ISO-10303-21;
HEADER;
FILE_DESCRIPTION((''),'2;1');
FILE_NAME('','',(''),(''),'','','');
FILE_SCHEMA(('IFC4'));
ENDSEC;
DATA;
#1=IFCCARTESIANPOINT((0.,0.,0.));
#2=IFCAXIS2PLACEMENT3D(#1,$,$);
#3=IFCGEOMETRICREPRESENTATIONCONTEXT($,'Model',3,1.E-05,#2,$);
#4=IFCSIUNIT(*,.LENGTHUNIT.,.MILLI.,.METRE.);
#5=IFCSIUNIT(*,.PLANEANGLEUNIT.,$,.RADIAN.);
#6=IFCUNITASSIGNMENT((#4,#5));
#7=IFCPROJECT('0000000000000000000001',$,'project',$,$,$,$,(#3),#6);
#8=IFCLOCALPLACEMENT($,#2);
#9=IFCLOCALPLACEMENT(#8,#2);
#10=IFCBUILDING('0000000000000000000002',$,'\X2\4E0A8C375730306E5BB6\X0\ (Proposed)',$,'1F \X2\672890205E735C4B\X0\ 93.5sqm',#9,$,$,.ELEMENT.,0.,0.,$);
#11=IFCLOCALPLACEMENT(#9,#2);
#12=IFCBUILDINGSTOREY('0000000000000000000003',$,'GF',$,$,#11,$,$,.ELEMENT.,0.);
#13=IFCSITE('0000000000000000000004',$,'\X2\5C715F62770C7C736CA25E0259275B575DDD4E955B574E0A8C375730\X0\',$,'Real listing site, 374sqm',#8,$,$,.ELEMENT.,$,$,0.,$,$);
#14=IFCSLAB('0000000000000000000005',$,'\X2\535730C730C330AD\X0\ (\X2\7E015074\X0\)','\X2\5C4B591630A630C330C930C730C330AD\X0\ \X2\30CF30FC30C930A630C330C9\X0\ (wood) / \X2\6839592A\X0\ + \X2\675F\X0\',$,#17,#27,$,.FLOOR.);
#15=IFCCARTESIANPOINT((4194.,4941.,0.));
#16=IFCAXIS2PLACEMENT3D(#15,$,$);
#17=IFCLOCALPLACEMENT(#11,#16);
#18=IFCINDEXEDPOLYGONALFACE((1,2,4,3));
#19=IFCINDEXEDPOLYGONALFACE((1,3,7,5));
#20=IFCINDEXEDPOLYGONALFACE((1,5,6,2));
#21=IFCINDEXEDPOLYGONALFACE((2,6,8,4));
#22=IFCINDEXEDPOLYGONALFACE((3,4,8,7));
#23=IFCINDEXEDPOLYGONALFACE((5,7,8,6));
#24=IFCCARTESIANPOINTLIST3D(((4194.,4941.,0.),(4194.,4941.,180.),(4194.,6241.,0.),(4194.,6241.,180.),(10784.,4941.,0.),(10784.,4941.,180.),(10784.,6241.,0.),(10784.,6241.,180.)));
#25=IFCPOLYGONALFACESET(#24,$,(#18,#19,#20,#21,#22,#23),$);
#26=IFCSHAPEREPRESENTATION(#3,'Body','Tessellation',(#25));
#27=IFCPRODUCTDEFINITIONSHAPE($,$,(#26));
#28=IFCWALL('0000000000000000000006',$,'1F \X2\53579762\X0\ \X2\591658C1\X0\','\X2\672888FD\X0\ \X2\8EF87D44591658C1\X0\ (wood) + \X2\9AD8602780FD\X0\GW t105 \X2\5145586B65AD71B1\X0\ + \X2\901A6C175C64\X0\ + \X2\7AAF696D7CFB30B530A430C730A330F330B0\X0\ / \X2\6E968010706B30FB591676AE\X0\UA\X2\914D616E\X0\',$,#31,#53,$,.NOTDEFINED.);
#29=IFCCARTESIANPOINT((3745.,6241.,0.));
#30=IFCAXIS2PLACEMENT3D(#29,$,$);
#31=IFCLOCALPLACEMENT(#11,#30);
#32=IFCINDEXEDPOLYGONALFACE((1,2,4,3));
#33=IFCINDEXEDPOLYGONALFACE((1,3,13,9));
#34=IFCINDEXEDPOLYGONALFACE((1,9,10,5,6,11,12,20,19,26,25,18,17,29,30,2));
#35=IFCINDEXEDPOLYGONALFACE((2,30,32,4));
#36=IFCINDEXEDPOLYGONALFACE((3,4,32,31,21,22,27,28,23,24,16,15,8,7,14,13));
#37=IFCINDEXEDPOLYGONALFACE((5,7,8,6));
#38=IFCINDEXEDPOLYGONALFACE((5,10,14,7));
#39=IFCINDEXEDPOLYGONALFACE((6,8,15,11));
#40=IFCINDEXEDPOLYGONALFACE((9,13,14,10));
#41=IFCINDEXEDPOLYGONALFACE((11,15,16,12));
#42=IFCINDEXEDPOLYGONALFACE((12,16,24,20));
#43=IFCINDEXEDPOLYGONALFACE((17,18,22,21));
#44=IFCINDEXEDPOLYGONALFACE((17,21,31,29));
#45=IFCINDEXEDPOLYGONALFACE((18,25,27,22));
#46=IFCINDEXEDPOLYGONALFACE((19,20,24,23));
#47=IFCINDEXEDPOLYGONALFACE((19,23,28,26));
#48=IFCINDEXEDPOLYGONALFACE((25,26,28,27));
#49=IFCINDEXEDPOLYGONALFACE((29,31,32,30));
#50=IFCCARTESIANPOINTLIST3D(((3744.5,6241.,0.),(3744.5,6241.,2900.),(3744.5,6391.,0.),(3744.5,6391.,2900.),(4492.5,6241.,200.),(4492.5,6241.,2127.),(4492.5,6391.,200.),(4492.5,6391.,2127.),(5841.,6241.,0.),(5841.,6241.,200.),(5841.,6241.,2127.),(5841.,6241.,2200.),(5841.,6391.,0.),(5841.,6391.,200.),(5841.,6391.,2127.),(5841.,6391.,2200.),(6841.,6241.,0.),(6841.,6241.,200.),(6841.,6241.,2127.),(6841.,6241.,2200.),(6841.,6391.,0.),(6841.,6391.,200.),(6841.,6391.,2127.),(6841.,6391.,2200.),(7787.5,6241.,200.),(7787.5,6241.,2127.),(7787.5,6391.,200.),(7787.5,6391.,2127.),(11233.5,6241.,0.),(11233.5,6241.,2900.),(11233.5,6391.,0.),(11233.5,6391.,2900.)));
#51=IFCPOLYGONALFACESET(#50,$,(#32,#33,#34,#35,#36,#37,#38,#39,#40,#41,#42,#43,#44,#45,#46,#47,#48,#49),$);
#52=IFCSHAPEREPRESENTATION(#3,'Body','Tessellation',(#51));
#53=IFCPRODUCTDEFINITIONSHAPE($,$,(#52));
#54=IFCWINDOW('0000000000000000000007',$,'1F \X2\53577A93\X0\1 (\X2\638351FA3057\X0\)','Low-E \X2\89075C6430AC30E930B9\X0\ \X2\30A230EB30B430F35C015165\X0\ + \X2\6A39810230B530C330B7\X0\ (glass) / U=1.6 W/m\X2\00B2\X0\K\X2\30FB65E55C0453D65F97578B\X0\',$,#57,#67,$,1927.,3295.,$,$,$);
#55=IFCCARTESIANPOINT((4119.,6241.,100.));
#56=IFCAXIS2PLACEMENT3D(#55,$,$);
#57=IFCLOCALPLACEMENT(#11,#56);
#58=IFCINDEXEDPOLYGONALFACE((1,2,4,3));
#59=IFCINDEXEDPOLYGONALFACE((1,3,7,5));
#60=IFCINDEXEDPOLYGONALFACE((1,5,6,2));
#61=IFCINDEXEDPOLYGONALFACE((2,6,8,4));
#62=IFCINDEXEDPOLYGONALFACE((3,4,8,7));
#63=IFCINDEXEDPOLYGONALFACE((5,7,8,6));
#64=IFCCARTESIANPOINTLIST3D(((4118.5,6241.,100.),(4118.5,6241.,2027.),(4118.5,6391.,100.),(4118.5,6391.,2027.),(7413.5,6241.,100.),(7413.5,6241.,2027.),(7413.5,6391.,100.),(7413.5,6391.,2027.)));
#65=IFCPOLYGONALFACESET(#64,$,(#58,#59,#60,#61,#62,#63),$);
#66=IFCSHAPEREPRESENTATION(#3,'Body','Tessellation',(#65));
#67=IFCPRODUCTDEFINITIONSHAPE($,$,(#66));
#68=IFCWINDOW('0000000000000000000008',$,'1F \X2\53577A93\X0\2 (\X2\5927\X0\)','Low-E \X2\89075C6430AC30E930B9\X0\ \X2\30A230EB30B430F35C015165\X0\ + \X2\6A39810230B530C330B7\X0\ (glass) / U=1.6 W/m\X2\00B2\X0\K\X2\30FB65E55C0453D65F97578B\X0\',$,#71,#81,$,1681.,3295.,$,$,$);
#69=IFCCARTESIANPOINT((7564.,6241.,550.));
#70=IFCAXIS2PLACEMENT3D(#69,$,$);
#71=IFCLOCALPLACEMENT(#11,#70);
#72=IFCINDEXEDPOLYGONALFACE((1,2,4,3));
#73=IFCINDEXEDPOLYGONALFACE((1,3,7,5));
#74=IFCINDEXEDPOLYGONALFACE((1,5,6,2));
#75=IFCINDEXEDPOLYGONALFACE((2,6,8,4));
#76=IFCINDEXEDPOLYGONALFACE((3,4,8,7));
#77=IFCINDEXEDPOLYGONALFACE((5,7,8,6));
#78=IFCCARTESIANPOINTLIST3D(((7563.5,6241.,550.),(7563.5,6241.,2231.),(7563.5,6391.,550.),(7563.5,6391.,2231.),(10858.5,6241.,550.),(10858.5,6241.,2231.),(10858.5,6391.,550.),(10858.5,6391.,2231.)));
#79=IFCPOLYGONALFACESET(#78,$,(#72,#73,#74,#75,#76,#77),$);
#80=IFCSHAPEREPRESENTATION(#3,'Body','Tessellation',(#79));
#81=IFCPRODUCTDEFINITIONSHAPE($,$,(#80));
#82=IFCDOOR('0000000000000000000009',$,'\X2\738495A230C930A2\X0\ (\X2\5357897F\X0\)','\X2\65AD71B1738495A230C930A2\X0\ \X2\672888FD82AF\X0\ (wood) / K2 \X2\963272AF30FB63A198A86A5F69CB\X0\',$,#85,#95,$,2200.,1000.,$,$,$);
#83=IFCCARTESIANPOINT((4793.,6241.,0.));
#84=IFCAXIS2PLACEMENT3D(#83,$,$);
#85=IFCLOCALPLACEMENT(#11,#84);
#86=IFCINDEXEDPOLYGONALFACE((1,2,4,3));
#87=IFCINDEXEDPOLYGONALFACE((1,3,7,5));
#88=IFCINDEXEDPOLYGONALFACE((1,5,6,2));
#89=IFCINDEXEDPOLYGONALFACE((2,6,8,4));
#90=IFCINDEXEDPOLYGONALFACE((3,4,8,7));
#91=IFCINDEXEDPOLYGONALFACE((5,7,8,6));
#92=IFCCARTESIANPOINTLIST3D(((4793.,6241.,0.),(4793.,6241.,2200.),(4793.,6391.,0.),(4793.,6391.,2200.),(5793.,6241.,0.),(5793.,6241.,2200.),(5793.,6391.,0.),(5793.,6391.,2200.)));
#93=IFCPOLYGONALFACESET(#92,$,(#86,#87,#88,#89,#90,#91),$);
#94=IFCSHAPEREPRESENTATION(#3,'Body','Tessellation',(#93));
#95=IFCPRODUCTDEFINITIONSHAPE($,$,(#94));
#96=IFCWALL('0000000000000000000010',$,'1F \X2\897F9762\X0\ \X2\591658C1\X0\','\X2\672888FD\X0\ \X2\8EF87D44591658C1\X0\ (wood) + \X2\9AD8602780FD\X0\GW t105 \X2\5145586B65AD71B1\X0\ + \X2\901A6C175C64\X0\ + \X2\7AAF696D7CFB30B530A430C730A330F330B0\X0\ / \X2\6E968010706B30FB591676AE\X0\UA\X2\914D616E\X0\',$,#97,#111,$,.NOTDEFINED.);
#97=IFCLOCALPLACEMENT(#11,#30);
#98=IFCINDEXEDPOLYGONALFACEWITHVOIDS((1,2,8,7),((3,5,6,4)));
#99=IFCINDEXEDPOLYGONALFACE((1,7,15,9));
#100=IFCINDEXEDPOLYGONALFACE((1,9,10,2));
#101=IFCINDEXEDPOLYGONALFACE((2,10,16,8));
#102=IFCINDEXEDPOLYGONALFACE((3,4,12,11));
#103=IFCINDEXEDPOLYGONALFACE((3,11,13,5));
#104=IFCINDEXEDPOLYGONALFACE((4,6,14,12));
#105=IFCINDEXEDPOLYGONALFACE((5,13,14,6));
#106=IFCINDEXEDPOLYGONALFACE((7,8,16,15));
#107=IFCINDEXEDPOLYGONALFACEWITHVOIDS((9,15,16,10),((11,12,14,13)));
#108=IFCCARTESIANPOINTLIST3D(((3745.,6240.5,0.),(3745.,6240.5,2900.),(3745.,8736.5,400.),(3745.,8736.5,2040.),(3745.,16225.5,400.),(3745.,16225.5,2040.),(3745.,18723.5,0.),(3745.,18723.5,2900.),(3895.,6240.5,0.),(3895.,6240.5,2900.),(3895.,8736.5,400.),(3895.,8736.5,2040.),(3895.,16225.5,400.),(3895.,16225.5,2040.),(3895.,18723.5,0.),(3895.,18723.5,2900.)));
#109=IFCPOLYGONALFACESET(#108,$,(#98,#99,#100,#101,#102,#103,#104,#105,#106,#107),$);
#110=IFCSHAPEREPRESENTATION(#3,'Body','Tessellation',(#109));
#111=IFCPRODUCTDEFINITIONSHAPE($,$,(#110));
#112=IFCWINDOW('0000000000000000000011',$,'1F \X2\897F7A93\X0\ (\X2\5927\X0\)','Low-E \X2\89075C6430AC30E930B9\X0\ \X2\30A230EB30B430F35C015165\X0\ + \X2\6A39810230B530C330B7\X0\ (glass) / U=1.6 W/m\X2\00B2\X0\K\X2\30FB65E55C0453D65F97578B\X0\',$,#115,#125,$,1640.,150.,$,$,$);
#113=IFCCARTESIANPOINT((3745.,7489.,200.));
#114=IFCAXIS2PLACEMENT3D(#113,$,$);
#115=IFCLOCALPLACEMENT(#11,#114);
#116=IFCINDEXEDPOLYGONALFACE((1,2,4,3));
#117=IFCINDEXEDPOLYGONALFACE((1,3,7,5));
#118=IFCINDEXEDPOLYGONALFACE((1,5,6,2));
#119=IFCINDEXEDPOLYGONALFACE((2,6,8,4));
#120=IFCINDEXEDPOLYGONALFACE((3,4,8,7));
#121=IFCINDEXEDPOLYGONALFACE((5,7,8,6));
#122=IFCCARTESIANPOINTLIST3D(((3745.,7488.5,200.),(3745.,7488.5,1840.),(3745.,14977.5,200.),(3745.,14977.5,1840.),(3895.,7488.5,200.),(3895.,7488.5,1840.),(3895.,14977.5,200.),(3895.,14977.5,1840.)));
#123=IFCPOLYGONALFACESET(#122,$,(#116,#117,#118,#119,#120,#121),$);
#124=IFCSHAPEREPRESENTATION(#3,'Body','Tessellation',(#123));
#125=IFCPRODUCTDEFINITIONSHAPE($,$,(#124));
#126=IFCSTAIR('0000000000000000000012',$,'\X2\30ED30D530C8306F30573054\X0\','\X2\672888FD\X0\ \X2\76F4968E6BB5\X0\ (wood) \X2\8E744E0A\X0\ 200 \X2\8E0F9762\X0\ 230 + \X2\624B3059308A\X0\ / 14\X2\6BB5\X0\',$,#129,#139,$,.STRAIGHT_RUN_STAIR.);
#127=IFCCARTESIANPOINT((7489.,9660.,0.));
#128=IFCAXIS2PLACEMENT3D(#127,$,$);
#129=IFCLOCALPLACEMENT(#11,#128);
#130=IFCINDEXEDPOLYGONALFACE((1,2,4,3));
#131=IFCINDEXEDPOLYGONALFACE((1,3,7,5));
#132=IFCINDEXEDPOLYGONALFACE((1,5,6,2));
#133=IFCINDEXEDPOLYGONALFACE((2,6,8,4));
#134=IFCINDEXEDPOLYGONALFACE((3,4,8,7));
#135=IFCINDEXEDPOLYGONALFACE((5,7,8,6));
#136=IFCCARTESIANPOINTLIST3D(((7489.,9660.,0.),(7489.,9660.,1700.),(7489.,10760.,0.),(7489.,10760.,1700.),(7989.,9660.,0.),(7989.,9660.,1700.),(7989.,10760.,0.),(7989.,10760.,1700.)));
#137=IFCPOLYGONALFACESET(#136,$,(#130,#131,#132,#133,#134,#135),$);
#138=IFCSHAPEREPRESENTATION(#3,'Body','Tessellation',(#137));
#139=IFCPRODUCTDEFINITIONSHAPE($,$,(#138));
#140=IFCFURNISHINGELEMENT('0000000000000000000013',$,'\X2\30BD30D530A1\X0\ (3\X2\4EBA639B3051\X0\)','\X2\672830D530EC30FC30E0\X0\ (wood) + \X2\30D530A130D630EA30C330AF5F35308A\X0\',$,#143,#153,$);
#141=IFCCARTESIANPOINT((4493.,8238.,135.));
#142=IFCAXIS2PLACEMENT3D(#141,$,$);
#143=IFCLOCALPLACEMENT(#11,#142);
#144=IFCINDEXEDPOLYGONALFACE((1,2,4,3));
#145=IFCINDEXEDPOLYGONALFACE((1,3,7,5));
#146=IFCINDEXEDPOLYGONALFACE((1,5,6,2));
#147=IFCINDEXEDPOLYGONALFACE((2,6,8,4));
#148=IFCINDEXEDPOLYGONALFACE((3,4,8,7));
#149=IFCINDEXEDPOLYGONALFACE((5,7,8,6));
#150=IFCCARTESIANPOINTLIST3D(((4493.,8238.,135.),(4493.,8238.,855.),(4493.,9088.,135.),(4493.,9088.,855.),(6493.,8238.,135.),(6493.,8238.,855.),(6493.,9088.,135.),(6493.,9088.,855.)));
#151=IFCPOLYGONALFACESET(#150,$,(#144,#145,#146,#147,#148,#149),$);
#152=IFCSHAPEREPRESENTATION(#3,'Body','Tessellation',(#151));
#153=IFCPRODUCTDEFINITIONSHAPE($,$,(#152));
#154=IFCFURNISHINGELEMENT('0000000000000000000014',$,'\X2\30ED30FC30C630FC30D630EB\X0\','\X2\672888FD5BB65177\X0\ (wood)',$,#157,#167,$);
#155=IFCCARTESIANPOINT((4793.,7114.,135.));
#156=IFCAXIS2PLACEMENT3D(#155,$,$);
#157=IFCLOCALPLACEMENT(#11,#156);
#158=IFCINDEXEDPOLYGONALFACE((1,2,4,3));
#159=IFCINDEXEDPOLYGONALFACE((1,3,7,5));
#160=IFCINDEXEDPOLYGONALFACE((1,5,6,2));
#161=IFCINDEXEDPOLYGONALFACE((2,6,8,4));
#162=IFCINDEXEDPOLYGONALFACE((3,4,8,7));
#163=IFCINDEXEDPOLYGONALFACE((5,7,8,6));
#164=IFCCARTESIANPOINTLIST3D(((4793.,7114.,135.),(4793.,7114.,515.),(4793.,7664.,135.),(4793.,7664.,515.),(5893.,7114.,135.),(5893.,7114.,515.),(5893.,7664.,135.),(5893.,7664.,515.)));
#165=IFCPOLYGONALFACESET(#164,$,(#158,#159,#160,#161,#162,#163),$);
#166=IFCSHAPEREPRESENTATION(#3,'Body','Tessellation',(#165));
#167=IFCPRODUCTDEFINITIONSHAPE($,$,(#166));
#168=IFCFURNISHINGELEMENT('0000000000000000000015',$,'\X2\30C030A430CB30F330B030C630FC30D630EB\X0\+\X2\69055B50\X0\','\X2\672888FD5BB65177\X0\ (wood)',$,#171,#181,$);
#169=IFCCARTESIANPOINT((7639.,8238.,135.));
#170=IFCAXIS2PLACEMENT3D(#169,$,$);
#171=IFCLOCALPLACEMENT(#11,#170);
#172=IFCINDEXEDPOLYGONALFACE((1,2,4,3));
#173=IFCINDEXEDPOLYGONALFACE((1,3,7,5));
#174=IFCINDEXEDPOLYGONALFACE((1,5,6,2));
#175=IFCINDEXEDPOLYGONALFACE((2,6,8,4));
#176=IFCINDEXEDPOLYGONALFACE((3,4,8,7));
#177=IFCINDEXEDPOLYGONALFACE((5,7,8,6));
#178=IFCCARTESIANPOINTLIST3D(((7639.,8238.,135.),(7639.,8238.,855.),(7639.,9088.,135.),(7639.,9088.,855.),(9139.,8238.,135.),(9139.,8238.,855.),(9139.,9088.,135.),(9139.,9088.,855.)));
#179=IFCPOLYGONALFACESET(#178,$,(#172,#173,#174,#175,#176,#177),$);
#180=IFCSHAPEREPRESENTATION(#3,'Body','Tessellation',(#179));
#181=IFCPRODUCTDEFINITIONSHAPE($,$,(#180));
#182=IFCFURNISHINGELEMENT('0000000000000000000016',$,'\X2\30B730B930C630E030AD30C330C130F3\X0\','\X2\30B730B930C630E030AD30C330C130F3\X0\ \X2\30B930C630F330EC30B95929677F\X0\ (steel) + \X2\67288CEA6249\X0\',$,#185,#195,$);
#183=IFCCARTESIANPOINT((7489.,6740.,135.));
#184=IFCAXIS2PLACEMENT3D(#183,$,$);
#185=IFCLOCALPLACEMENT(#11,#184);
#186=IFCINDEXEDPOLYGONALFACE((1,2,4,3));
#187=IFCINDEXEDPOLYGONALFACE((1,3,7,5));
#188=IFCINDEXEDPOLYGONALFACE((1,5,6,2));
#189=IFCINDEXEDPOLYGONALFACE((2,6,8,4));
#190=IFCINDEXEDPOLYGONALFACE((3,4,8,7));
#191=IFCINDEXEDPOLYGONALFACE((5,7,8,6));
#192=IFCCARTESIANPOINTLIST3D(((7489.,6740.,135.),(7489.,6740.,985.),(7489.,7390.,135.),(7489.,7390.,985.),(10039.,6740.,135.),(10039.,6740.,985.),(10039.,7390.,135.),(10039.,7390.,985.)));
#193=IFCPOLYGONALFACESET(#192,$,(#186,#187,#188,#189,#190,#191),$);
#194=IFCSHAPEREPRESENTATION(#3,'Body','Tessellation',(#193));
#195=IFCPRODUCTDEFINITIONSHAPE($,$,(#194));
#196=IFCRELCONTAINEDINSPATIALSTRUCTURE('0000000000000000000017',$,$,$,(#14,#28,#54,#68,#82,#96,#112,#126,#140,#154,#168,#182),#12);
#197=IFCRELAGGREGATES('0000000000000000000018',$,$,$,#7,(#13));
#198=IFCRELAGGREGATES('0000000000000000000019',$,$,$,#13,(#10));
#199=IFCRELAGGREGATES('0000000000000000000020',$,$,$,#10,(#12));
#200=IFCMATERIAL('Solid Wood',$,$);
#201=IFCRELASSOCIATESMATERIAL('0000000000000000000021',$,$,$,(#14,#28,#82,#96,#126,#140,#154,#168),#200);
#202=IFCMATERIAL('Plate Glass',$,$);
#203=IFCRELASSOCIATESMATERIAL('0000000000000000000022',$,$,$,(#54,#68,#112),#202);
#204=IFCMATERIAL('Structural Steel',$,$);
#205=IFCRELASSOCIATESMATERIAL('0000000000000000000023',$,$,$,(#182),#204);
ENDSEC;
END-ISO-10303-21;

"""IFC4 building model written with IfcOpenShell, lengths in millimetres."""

from ifc_helpers import new_model, si_unit, frame, frame_2d, origin, place, context, project, spatial, rectangle, extrude, material, element, fill, save


model = new_model("IFC4")

# Units and contexts
model_context = context("Model", 3, precision=1e-05, world=origin())
ifc_project = project(units=[si_unit("LENGTHUNIT", "METRE", prefix="MILLI"), si_unit("PLANEANGLEUNIT", "RADIAN")], contexts=[model_context])

# Site, building, storey
site_placement = place(None, origin())
site = spatial("IfcSite", under=ifc_project, at=site_placement, Name="山形県米沢市大字川井字上谷地", ObjectType="Real listing site, 374sqm", CompositionType="ELEMENT", RefElevation=0.0)
building_placement = place(site_placement, origin())
building = spatial("IfcBuilding", under=site, at=building_placement, Name="上谷地の家 (Proposed)", ObjectType="1F 木造平屋 93.5sqm", CompositionType="ELEMENT", ElevationOfRefHeight=0.0, ElevationOfTerrain=0.0)
storey_placement = place(building_placement, origin())
storey = spatial("IfcBuildingStorey", under=building, at=storey_placement, Name="GF", CompositionType="ELEMENT", Elevation=0.0)

# Slab
ifc_material_1 = material(Name="Solid Wood")
slab_1_placement = place(storey_placement, frame((4194.0, 4941.0, 0.0)))
element("IfcSlab", 1, at=slab_1_placement, inside=storey, material=ifc_material_1, Name="南デッキ (縁側)", Description="屋外ウッドデッキ ハードウッド (wood) / 根太 + 束", PredefinedType="FLOOR", context=model_context, shape_type="SweptSolid", body=[
    extrude(rectangle(XDim=6590.0, YDim=1300.0, at=frame_2d((3295.0, 650.0))), frame((4194.0, 4941.0, 0.0)), (0.0, 0.0, 1.0), 180.0),
])

# Wall, openings, windows, door
wall_1_placement = place(storey_placement, frame((3745.0, 6241.0, 0.0)))
wall_1 = element("IfcWall", 2, at=wall_1_placement, inside=storey, material=ifc_material_1, Name="1F 南面 外壁", Description="木製 軸組外壁 (wood) + 高性能GW t105 充填断熱 + 通気層 + 窯業系サイディング / 準耐火・外皮UA配慮", PredefinedType="NOTDEFINED", context=model_context, shape_type="SweptSolid", body=[
    extrude(rectangle(XDim=7489.0, YDim=150.0, at=frame_2d((3744.0, 75.0))), frame((3745.0, 6241.0, 0.0)), (0.0, 0.0, 1.0), 2900.0),
])
opening_1_placement = place(storey_placement, frame((4119.0, 6241.0, 100.0)))
opening_1 = element("IfcOpeningElement", 3, at=opening_1_placement, cuts=wall_1, PredefinedType="NOTDEFINED", context=model_context, shape_type="SweptSolid", body=[
    extrude(rectangle(XDim=3295.0, YDim=150.0, at=frame_2d((1647.0, 75.0))), frame((4119.0, 6241.0, 100.0)), (0.0, 0.0, 1.0), 1927.0),
])
opening_2_placement = place(storey_placement, frame((7564.0, 6241.0, 550.0)))
opening_2 = element("IfcOpeningElement", 4, at=opening_2_placement, cuts=wall_1, PredefinedType="NOTDEFINED", context=model_context, shape_type="SweptSolid", body=[
    extrude(rectangle(XDim=3295.0, YDim=150.0, at=frame_2d((1647.0, 75.0))), frame((7564.0, 6241.0, 550.0)), (0.0, 0.0, 1.0), 1681.0),
])
opening_3_placement = place(storey_placement, frame((4793.0, 6241.0, 0.0)))
opening_3 = element("IfcOpeningElement", 5, at=opening_3_placement, cuts=wall_1, PredefinedType="NOTDEFINED", context=model_context, shape_type="SweptSolid", body=[
    extrude(rectangle(XDim=1000.0, YDim=150.0, at=frame_2d((500.0, 75.0))), frame((4793.0, 6241.0, 0.0)), (0.0, 0.0, 1.0), 2200.0),
])
ifc_material_2 = material(Name="Plate Glass")
window_1_placement = place(storey_placement, frame((4119.0, 6241.0, 100.0)))
window_1 = element("IfcWindow", 6, at=window_1_placement, inside=storey, material=ifc_material_2, Name="1F 南窓1 (掃出し)", Description="Low-E 複層ガラス アルゴン封入 + 樹脂サッシ (glass) / U=1.6 W/m²K・日射取得型", OverallHeight=1927.0, OverallWidth=3295.0, context=model_context, shape_type="SweptSolid", body=[
    extrude(rectangle(XDim=3295.0, YDim=150.0, at=frame_2d((1647.0, 75.0))), frame((4119.0, 6241.0, 100.0)), (0.0, 0.0, 1.0), 1927.0),
])
fill(opening_1, window_1)
window_2_placement = place(storey_placement, frame((7564.0, 6241.0, 550.0)))
window_2 = element("IfcWindow", 7, at=window_2_placement, inside=storey, material=ifc_material_2, Name="1F 南窓2 (大)", Description="Low-E 複層ガラス アルゴン封入 + 樹脂サッシ (glass) / U=1.6 W/m²K・日射取得型", OverallHeight=1681.0, OverallWidth=3295.0, context=model_context, shape_type="SweptSolid", body=[
    extrude(rectangle(XDim=3295.0, YDim=150.0, at=frame_2d((1647.0, 75.0))), frame((7564.0, 6241.0, 550.0)), (0.0, 0.0, 1.0), 1681.0),
])
fill(opening_2, window_2)
door_placement = place(storey_placement, frame((4793.0, 6241.0, 0.0)))
door = element("IfcDoor", 8, at=door_placement, inside=storey, material=ifc_material_1, Name="玄関ドア (南西)", Description="断熱玄関ドア 木製芯 (wood) / K2 防犯・採風機構", OverallHeight=2200.0, OverallWidth=1000.0, context=model_context, shape_type="SweptSolid", body=[
    extrude(rectangle(XDim=1000.0, YDim=150.0, at=frame_2d((500.0, 75.0))), frame((4793.0, 6241.0, 0.0)), (0.0, 0.0, 1.0), 2200.0),
])
fill(opening_3, door)

# Wall, opening, window
wall_2_placement = place(storey_placement, frame((3745.0, 6241.0, 0.0)))
wall_2 = element("IfcWall", 9, at=wall_2_placement, inside=storey, material=ifc_material_1, Name="1F 西面 外壁", Description="木製 軸組外壁 (wood) + 高性能GW t105 充填断熱 + 通気層 + 窯業系サイディング / 準耐火・外皮UA配慮", PredefinedType="NOTDEFINED", context=model_context, shape_type="SweptSolid", body=[
    extrude(rectangle(XDim=150.0, YDim=12483.0, at=frame_2d((75.0, 6241.0))), frame((3745.0, 6241.0, 0.0)), (0.0, 0.0, 1.0), 2900.0),
])
opening_4_placement = place(storey_placement, frame((3745.0, 7489.0, 200.0)))
opening_4 = element("IfcOpeningElement", 10, at=opening_4_placement, cuts=wall_2, PredefinedType="NOTDEFINED", context=model_context, shape_type="SweptSolid", body=[
    extrude(rectangle(XDim=150.0, YDim=7489.0, at=frame_2d((75.0, 3744.0))), frame((3745.0, 7489.0, 200.0)), (0.0, 0.0, 1.0), 1640.0),
])
window_3_placement = place(storey_placement, frame((3745.0, 7489.0, 200.0)))
window_3 = element("IfcWindow", 11, at=window_3_placement, inside=storey, material=ifc_material_2, Name="1F 西窓 (大)", Description="Low-E 複層ガラス アルゴン封入 + 樹脂サッシ (glass) / U=1.6 W/m²K・日射取得型", OverallHeight=1640.0, OverallWidth=150.0, context=model_context, shape_type="SweptSolid", body=[
    extrude(rectangle(XDim=150.0, YDim=7489.0, at=frame_2d((75.0, 3744.0))), frame((3745.0, 7489.0, 200.0)), (0.0, 0.0, 1.0), 1640.0),
])
fill(opening_4, window_3)

# Stair
stair_placement = place(storey_placement, frame((7489.0, 9660.0, 0.0)))
element("IfcStair", 12, at=stair_placement, inside=storey, material=ifc_material_1, Name="ロフトはしご", Description="木製 直階段 (wood) 蹴上 200 踏面 230 + 手すり / 14段", PredefinedType="STRAIGHT_RUN_STAIR", context=model_context, shape_type="SweptSolid", body=[
    extrude(rectangle(XDim=500.0, YDim=1100.0, at=frame_2d((250.0, 550.0))), frame((7489.0, 9660.0, 0.0)), (0.0, 0.0, 1.0), 1700.0),
])

# Shared definitions
ifc_material_3 = material(Name="Structural Steel")

# Furnishing elements
furnishing_1_placement = place(storey_placement, frame((4493.0, 8238.0, 135.0)))
element("IfcFurnishingElement", 13, at=furnishing_1_placement, inside=storey, material=ifc_material_1, Name="ソファ (3人掛け)", Description="木フレーム (wood) + ファブリック張り", context=model_context, shape_type="SweptSolid", body=[
    extrude(rectangle(XDim=2000.0, YDim=850.0, at=frame_2d((1000.0, 425.0))), frame((4493.0, 8238.0, 135.0)), (0.0, 0.0, 1.0), 720.0),
])
furnishing_2_placement = place(storey_placement, frame((4793.0, 7114.0, 135.0)))
element("IfcFurnishingElement", 14, at=furnishing_2_placement, inside=storey, material=ifc_material_1, Name="ローテーブル", Description="木製家具 (wood)", context=model_context, shape_type="SweptSolid", body=[
    extrude(rectangle(XDim=1100.0, YDim=550.0, at=frame_2d((550.0, 275.0))), frame((4793.0, 7114.0, 135.0)), (0.0, 0.0, 1.0), 380.0),
])
furnishing_3_placement = place(storey_placement, frame((7639.0, 8238.0, 135.0)))
element("IfcFurnishingElement", 15, at=furnishing_3_placement, inside=storey, material=ifc_material_1, Name="ダイニングテーブル+椅子", Description="木製家具 (wood)", context=model_context, shape_type="SweptSolid", body=[
    extrude(rectangle(XDim=1500.0, YDim=850.0, at=frame_2d((750.0, 425.0))), frame((7639.0, 8238.0, 135.0)), (0.0, 0.0, 1.0), 720.0),
])
furnishing_4_placement = place(storey_placement, frame((7489.0, 6740.0, 135.0)))
element("IfcFurnishingElement", 16, at=furnishing_4_placement, inside=storey, material=ifc_material_3, Name="システムキッチン", Description="システムキッチン ステンレス天板 (steel) + 木質扉", context=model_context, shape_type="SweptSolid", body=[
    extrude(rectangle(XDim=2550.0, YDim=650.0, at=frame_2d((1275.0, 325.0))), frame((7489.0, 6740.0, 135.0)), (0.0, 0.0, 1.0), 850.0),
])

save(model, "model.ifc")
